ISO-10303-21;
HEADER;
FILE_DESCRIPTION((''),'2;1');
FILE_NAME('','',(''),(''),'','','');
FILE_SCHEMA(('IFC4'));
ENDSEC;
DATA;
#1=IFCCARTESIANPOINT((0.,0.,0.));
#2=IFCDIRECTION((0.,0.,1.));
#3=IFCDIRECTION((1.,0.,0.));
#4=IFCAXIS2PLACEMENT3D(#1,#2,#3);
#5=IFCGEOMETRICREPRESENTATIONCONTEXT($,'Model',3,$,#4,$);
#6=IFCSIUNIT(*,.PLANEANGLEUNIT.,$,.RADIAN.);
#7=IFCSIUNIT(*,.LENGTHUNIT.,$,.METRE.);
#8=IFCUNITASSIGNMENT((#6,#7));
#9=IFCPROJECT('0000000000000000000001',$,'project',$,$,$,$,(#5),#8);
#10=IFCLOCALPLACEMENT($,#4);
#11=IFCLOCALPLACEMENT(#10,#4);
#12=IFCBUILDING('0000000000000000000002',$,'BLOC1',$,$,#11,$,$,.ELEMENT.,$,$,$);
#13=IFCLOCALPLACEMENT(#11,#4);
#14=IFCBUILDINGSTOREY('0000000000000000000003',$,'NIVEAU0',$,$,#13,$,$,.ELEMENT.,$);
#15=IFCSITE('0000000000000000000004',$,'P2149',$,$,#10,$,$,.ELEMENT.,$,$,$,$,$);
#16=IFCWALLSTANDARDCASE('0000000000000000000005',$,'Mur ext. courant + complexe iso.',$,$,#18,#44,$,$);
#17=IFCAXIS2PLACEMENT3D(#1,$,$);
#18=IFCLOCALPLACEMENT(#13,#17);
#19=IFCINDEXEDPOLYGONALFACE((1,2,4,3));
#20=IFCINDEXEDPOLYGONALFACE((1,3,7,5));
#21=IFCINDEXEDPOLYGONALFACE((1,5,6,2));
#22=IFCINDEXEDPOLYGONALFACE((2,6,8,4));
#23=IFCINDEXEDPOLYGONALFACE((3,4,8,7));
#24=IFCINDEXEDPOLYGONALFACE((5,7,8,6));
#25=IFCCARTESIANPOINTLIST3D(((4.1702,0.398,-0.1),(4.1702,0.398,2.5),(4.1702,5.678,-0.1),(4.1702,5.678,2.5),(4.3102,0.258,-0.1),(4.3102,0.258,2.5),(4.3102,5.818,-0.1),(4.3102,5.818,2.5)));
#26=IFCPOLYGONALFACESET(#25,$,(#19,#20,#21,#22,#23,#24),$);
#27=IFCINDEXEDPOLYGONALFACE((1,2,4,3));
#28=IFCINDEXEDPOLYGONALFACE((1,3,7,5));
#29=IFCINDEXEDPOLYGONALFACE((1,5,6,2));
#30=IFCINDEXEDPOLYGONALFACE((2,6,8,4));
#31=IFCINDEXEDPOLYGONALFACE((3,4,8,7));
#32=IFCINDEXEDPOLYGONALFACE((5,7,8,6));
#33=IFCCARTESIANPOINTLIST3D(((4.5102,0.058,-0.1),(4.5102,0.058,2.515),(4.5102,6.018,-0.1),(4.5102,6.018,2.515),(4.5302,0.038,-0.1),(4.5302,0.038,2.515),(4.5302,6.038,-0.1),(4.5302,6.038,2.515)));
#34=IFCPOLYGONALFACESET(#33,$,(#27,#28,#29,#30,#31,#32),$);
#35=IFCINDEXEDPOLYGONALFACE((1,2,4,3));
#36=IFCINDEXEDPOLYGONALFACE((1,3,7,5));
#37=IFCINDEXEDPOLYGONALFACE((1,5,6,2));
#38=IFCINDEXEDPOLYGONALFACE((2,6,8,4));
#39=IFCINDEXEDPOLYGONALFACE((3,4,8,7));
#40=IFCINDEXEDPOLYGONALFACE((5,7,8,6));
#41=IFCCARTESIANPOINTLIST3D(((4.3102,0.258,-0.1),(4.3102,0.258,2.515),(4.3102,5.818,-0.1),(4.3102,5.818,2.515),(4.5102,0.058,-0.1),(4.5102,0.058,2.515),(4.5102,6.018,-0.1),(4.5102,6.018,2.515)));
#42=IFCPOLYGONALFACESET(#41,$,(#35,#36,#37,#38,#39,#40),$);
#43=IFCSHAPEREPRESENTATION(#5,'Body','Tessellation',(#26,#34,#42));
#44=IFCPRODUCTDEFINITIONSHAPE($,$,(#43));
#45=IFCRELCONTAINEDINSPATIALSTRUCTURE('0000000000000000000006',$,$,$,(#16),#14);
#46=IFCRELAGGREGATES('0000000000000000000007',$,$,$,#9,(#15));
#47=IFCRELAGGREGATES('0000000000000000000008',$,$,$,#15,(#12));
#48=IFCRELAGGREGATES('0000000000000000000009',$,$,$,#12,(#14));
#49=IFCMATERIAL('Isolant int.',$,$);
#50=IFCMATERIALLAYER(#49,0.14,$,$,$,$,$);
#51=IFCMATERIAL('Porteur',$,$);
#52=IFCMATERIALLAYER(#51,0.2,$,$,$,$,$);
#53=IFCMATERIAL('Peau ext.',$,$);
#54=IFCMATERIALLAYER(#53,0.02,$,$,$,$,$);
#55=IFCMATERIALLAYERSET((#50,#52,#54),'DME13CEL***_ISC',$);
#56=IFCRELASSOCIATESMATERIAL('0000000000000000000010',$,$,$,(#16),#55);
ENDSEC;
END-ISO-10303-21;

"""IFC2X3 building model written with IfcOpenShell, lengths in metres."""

from ifc_helpers import new_model, si_unit, point, frame, origin_with_axes, place, context, project, spatial, line_curve, trimmed, segment, composite_curve, outline, extrude, clip, bounded_halfspace, material, layer, layer_set, layer_usage, element, save


model = new_model("IFC2X3")

# Units and contexts
model_context = context("Model", 3, world=origin_with_axes())
ifc_project = project(units=[si_unit("PLANEANGLEUNIT", "RADIAN"), si_unit("LENGTHUNIT", "METRE")], contexts=[model_context])

# Site, building, storey
site_placement = place(None, origin_with_axes())
site = spatial("IfcSite", under=ifc_project, at=site_placement, Name="P2149", CompositionType="ELEMENT")
building_placement = place(site_placement, origin_with_axes())
building = spatial("IfcBuilding", under=site, at=building_placement, Name="BLOC1", CompositionType="ELEMENT")
storey_placement = place(building_placement, origin_with_axes())
storey = spatial("IfcBuildingStorey", under=building, at=storey_placement, Name="NIVEAU0", CompositionType="ELEMENT")

# Wall
ifc_material_1 = material(Name="Isolant int.")
ifc_layer_1 = layer(ifc_material_1, 0.14)
ifc_material_2 = material(Name="Porteur")
ifc_layer_2 = layer(ifc_material_2, 0.2)
ifc_material_3 = material(Name="Peau ext.")
ifc_layer_3 = layer(ifc_material_3, 0.02)
ifc_layer_set_1 = layer_set([ifc_layer_1, ifc_layer_2, ifc_layer_3], Name="DME13CEL***_ISC")
ifc_layer_usage_1 = layer_usage(ifc_layer_set_1, "AXIS2", "POSITIVE", 0.0)
wall_1_placement = place(storey_placement, frame((4.1702, 5.678, -0.1), z_axis=(0.0, 0.0, 1.0), x_axis=(0.0, -1.0, 0.0)))
element("IfcWallStandardCase", 1, at=wall_1_placement, inside=storey, material=ifc_layer_usage_1, Name="Mur ext. courant + complexe iso.", context=model_context, shape_type="Clipping", body=[
    clip(extrude(outline(composite_curve([segment(trimmed(line_curve((0.0, 0.0), (1.0, 0.0), 5.28), [point((0.0, 0.0))], [point((5.28, 0.0))], True, "CARTESIAN"), True, "CONTINUOUS"), segment(trimmed(line_curve((5.28, 0.0), (0.707107, 0.707107), 0.19799), [point((5.28, 0.0))], [point((5.42, 0.14))], True, "CARTESIAN"), True, "CONTINUOUS"), segment(trimmed(line_curve((5.42, 0.14), (-1.0, 0.0), 5.56), [point((5.42, 0.14))], [point((-0.14, 0.14))], True, "CARTESIAN"), True, "CONTINUOUS"), segment(trimmed(line_curve((-0.14, 0.14), (0.707107, -0.707107), 0.19799), [point((-0.14, 0.14))], [point((0.0, 0.0))], True, "CARTESIAN"), True, "CONTINUOUS")], self_intersect=False)), origin_with_axes(), (0.0, 0.0, 1.0), 2.615), bounded_halfspace(frame((0.0, 0.0, 2.6), z_axis=(0.0, 0.0, 1.0), x_axis=(0.0, 1.0, 0.0)), False, frame((0.0, 0.0, 2.6), z_axis=(0.0, 0.0, 1.0), x_axis=(1.0, 0.0, 0.0)), composite_curve([segment(trimmed(line_curve((0.0, 0.0), (1.0, 0.0), 5.28), [point((0.0, 0.0))], [point((5.28, 0.0))], True, "CARTESIAN"), True, "CONTINUOUS"), segment(trimmed(line_curve((5.28, 0.0), (0.707107, 0.707107), 0.19799), [point((5.28, 0.0))], [point((5.42, 0.14))], True, "CARTESIAN"), True, "CONTINUOUS"), segment(trimmed(line_curve((5.42, 0.14), (-1.0, 0.0), 5.56), [point((5.42, 0.14))], [point((-0.14, 0.14))], True, "CARTESIAN"), True, "CONTINUOUS"), segment(trimmed(line_curve((-0.14, 0.14), (0.707107, -0.707107), 0.19799), [point((-0.14, 0.14))], [point((0.0, 0.0))], True, "CARTESIAN"), True, "CONTINUOUS")], self_intersect=False))),
    extrude(outline(composite_curve([segment(trimmed(line_curve((-0.34, 0.34), (1.0, 0.0), 5.96), [point((-0.34, 0.34))], [point((5.62, 0.34))], True, "CARTESIAN"), True, "CONTINUOUS"), segment(trimmed(line_curve((5.62, 0.34), (0.707107, 0.707107), 0.028284), [point((5.62, 0.34))], [point((5.64, 0.36))], True, "CARTESIAN"), True, "CONTINUOUS"), segment(trimmed(line_curve((5.64, 0.36), (-1.0, 0.0), 6.0), [point((5.64, 0.36))], [point((-0.36, 0.36))], True, "CARTESIAN"), True, "CONTINUOUS"), segment(trimmed(line_curve((-0.36, 0.36), (0.707107, -0.707107), 0.028284), [point((-0.36, 0.36))], [point((-0.34, 0.34))], True, "CARTESIAN"), True, "CONTINUOUS")], self_intersect=False)), origin_with_axes(), (0.0, 0.0, 1.0), 2.615),
    extrude(outline(composite_curve([segment(trimmed(line_curve((-0.14, 0.14), (1.0, 0.0), 5.56), [point((-0.14, 0.14))], [point((5.42, 0.14))], True, "CARTESIAN"), True, "CONTINUOUS"), segment(trimmed(line_curve((5.42, 0.14), (0.707107, 0.707107), 0.282843), [point((5.42, 0.14))], [point((5.62, 0.34))], True, "CARTESIAN"), True, "CONTINUOUS"), segment(trimmed(line_curve((5.62, 0.34), (-1.0, 0.0), 5.96), [point((5.62, 0.34))], [point((-0.34, 0.34))], True, "CARTESIAN"), True, "CONTINUOUS"), segment(trimmed(line_curve((-0.34, 0.34), (0.707107, -0.707107), 0.282843), [point((-0.34, 0.34))], [point((-0.14, 0.14))], True, "CARTESIAN"), True, "CONTINUOUS")], self_intersect=False)), origin_with_axes(), (0.0, 0.0, 1.0), 2.615),
])

save(model, "model.ifc")
